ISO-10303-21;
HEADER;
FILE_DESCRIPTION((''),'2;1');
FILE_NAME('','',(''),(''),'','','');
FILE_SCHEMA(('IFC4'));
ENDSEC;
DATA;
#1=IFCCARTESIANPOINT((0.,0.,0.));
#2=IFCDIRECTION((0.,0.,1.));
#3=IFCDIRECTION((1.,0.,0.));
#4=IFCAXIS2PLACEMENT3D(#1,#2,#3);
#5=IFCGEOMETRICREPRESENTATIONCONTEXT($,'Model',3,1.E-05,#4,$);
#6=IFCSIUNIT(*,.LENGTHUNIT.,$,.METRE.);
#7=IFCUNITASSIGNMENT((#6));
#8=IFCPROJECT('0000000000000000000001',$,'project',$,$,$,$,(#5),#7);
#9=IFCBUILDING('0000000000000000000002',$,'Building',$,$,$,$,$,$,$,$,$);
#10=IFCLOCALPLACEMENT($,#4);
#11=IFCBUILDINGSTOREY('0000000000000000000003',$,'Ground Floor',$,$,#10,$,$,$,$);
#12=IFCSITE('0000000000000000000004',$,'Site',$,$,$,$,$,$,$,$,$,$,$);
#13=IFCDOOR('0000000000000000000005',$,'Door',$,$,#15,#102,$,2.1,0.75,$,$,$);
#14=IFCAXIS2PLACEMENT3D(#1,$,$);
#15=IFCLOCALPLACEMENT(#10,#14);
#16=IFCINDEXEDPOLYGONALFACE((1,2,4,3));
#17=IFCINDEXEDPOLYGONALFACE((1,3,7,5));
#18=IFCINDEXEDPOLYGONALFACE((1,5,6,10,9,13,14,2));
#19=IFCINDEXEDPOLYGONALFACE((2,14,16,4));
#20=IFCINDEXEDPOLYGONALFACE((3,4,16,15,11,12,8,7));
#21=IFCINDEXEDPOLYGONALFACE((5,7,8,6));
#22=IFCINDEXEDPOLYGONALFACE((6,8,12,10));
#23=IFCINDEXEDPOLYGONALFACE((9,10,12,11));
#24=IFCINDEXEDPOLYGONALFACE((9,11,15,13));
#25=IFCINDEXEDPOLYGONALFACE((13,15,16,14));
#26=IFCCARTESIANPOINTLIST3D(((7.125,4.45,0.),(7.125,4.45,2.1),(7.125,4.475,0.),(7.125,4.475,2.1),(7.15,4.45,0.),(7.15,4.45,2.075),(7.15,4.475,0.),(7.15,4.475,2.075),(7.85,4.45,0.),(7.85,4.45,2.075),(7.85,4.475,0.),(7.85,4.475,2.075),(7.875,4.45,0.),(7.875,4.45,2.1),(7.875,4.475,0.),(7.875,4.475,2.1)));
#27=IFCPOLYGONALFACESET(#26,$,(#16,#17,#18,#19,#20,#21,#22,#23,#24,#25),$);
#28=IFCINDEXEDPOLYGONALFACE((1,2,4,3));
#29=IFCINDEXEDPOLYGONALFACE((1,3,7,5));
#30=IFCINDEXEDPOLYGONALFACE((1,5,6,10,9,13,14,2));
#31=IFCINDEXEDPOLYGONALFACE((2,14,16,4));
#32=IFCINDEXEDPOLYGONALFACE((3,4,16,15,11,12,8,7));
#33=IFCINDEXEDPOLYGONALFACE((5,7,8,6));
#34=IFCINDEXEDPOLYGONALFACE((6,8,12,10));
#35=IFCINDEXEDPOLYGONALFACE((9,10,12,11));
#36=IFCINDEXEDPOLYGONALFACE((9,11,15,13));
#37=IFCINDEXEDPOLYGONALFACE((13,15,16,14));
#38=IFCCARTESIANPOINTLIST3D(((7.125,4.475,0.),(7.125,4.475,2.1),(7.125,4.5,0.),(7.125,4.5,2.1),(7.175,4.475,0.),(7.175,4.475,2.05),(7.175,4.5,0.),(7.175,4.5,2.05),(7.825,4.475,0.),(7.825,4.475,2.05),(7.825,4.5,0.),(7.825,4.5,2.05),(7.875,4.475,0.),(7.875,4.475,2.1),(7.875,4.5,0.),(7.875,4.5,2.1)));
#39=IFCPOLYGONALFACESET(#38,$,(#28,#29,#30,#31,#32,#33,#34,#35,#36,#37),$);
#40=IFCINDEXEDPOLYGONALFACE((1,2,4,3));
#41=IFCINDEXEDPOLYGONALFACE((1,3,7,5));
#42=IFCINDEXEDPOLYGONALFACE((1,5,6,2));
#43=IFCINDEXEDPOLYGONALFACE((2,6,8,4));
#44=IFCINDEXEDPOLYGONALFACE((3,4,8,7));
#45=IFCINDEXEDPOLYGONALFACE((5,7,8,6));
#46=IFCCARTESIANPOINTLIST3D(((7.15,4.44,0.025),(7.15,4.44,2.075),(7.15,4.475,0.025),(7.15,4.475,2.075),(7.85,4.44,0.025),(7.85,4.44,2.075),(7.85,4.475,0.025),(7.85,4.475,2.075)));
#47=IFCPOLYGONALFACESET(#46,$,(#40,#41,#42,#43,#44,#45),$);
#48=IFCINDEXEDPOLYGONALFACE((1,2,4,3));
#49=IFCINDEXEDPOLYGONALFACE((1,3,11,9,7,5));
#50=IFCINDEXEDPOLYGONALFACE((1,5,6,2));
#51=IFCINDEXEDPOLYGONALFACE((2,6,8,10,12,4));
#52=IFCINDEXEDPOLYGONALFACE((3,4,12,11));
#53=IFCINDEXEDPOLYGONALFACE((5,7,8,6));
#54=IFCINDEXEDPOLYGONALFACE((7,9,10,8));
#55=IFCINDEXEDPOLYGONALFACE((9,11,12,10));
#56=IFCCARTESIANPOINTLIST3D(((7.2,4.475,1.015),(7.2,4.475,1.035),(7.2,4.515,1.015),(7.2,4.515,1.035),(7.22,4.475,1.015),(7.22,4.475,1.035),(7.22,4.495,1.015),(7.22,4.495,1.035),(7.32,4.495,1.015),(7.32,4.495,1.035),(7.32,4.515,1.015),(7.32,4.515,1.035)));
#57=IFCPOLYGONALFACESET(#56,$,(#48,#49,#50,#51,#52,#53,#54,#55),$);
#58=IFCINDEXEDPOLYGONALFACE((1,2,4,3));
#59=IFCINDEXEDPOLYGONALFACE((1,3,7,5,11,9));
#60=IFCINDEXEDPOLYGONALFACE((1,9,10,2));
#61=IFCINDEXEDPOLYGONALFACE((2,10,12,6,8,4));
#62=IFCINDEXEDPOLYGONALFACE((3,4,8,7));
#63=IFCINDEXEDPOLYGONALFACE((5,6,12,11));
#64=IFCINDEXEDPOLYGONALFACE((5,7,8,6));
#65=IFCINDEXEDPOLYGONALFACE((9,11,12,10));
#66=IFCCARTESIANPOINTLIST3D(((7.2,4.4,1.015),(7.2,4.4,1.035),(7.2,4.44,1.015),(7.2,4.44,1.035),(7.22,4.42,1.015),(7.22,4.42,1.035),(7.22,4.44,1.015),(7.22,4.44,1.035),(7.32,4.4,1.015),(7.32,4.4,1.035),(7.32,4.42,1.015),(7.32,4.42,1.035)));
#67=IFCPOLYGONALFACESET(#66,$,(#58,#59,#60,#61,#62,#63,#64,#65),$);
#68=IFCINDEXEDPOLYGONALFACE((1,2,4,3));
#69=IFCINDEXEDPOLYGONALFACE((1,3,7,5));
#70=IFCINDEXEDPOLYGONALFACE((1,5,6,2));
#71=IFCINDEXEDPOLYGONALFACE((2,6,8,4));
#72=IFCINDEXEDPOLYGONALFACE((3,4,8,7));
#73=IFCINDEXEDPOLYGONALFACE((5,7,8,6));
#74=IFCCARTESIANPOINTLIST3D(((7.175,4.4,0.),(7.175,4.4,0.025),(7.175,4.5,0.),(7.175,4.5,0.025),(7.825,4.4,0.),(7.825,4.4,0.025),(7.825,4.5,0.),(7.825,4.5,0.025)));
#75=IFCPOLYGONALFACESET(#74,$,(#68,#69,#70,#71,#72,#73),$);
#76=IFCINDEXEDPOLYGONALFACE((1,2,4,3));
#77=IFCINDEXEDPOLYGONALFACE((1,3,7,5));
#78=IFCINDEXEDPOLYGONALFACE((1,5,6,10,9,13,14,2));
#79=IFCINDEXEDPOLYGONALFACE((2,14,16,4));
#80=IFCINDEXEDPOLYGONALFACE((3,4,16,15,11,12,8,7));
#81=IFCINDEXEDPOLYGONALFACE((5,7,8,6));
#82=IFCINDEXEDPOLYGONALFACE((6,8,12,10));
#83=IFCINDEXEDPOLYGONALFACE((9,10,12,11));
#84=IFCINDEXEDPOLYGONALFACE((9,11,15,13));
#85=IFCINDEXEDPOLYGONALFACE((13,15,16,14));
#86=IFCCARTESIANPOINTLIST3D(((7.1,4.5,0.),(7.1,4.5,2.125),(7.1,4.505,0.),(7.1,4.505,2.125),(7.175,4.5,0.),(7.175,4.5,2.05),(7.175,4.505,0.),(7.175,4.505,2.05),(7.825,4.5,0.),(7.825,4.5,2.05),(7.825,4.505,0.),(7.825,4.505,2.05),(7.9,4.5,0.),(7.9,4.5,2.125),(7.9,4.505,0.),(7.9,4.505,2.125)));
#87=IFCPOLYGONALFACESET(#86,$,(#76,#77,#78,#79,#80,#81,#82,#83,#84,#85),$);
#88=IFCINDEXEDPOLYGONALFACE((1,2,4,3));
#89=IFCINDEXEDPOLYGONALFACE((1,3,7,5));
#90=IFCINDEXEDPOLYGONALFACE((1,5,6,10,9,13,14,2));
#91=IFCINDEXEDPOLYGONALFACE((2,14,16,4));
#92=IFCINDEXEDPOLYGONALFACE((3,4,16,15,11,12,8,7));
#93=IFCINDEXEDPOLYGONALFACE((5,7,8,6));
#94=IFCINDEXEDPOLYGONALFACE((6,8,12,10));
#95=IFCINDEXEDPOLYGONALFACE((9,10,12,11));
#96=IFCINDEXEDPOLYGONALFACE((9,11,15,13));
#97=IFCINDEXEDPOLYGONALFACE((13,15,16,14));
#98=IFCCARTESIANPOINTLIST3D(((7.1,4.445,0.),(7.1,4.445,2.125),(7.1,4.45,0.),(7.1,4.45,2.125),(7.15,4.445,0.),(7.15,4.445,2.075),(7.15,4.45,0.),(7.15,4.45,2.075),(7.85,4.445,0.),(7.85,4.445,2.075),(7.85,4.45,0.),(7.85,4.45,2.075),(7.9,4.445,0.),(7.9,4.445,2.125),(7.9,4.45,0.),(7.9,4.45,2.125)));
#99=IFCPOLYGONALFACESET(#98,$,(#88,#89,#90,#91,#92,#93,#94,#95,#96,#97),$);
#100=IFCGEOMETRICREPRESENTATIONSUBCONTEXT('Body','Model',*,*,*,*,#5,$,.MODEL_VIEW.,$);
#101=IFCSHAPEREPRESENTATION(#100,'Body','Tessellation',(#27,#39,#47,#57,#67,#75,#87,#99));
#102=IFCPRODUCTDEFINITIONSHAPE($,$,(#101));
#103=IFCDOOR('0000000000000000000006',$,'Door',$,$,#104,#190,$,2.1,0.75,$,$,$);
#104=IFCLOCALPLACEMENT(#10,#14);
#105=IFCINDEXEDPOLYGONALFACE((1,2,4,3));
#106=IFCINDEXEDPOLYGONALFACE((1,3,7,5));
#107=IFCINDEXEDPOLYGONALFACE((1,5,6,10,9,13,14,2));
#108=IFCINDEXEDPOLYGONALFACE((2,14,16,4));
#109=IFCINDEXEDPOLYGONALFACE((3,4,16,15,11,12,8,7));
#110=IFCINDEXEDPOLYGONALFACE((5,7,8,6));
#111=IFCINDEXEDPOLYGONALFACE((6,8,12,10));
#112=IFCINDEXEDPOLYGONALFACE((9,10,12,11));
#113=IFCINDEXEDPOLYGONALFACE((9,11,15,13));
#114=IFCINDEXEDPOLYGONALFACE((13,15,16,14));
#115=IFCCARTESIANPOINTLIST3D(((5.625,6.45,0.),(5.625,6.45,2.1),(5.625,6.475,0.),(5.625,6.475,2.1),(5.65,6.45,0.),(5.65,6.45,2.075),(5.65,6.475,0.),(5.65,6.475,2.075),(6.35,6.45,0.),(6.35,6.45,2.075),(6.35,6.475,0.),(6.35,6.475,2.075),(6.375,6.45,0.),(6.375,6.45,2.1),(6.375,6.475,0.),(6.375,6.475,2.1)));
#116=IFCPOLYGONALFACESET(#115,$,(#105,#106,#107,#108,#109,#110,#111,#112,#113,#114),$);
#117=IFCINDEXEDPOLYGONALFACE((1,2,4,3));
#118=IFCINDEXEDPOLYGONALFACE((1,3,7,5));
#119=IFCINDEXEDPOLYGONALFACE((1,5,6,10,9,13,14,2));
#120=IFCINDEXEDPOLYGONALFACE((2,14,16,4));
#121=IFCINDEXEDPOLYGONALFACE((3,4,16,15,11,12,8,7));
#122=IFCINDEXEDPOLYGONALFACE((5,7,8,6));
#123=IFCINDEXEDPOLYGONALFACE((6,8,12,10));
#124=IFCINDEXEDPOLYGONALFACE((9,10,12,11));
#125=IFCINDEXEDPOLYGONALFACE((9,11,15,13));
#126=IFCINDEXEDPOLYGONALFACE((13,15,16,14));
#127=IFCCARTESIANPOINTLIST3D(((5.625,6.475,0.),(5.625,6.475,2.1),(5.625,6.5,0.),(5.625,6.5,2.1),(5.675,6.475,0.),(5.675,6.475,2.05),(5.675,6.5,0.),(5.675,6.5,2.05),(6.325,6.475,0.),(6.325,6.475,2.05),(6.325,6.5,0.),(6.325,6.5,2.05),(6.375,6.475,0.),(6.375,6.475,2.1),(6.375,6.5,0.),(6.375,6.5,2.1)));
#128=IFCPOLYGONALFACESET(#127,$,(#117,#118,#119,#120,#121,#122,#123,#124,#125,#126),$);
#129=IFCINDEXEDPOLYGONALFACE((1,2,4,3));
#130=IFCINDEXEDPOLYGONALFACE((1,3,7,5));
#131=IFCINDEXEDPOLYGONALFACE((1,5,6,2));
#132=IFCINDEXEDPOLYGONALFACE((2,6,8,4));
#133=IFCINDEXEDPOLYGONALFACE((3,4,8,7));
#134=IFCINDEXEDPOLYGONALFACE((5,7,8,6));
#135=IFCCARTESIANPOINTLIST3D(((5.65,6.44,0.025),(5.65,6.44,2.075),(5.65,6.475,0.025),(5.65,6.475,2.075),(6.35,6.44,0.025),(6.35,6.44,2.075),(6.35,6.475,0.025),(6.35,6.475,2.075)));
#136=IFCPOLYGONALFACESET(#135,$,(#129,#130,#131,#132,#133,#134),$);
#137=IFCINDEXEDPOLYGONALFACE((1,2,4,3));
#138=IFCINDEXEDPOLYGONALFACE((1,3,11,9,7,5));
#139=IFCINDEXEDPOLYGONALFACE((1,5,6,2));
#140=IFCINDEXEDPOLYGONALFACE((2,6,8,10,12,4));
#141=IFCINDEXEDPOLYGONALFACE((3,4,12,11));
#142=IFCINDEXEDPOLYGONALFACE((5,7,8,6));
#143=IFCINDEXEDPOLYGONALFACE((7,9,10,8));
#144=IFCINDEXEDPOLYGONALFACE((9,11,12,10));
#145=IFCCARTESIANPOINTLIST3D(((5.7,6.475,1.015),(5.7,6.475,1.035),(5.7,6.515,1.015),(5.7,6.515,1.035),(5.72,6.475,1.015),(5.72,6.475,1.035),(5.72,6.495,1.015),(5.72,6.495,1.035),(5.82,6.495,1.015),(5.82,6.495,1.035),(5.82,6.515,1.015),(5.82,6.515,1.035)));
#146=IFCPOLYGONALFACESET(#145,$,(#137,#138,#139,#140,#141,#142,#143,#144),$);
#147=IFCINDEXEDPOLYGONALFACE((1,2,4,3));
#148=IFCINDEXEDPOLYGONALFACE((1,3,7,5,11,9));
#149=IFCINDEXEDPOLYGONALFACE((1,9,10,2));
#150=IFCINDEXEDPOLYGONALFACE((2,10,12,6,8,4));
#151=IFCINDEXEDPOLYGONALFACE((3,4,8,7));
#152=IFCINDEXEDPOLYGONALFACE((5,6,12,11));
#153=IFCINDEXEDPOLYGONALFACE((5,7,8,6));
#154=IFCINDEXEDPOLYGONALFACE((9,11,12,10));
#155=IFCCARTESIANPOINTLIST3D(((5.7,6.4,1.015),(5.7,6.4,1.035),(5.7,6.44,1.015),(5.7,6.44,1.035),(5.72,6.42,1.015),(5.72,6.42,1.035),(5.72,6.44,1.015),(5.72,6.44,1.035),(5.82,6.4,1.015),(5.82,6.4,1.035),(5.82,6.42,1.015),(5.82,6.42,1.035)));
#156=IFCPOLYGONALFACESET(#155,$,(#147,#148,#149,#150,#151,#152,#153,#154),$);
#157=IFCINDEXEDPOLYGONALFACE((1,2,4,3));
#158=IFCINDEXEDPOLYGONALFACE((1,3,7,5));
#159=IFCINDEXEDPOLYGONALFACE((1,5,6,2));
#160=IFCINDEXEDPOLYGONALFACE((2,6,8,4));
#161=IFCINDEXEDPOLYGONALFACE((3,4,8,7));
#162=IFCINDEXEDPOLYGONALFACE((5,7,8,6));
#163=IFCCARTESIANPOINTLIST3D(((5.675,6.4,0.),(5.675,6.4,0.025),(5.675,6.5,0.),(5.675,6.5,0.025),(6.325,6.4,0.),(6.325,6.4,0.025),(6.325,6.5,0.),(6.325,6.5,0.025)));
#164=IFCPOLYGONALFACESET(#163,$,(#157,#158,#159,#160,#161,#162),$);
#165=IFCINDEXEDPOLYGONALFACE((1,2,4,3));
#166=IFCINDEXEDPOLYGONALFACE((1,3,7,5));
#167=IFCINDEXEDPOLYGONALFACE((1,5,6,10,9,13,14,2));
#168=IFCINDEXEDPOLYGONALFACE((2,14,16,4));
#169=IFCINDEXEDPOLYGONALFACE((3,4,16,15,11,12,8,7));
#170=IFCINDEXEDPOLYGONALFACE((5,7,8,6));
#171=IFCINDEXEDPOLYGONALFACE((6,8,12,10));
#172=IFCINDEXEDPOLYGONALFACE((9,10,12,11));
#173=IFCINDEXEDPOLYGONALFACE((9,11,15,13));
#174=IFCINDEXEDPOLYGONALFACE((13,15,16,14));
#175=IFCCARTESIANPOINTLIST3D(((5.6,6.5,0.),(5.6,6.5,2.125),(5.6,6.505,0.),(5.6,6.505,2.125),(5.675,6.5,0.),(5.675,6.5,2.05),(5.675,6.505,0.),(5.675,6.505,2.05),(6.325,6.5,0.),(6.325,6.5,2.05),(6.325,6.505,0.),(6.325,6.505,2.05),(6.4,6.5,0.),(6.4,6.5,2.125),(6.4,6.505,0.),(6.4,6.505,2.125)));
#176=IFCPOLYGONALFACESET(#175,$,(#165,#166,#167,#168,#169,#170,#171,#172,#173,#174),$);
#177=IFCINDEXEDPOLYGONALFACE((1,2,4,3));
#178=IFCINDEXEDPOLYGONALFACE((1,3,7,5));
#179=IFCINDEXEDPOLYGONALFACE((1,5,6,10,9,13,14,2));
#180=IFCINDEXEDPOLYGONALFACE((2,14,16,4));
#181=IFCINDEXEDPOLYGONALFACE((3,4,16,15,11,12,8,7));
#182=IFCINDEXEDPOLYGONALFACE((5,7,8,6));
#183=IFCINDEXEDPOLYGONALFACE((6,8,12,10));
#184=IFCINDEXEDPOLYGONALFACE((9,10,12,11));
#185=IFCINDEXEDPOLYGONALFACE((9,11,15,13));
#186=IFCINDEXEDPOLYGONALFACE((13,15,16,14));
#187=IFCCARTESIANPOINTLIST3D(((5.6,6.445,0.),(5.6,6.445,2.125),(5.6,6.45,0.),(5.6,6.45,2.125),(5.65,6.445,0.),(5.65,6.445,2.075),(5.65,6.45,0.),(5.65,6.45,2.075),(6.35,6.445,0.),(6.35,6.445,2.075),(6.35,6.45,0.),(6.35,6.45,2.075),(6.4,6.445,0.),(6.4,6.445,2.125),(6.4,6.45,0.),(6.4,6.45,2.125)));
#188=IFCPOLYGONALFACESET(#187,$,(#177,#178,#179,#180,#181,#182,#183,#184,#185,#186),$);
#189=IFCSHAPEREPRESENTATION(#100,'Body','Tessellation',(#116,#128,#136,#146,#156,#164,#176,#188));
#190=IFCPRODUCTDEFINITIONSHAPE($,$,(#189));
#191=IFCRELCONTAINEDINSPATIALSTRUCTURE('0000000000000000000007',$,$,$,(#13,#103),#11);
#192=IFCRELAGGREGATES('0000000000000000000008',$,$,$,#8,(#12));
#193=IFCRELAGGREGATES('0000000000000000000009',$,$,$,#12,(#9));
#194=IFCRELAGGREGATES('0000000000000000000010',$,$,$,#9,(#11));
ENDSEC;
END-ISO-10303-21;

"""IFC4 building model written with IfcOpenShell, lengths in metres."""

from ifc_helpers import new_model, si_unit, frame, origin_with_axes, place, context, subcontext, project, spatial, line, indexed_curve, outline, extrude, element, save


model = new_model("IFC4")

# Units and contexts
model_context = context("Model", 3, precision=1e-05, world=origin_with_axes())
body_context = subcontext(model_context, "Body", "Model", "MODEL_VIEW")
ifc_project = project(units=[si_unit("LENGTHUNIT", "METRE")], contexts=[model_context])

# Site, building, storey
site = spatial("IfcSite", under=ifc_project, Name="Site")
building = spatial("IfcBuilding", under=site, Name="Building")
storey_placement = place(None, origin_with_axes())
storey = spatial("IfcBuildingStorey", under=building, at=storey_placement, Name="Ground Floor")

# Doors
door_1_placement = place(storey_placement, frame((7.875, 4.5, 0.0), z_axis=(0.0, 0.0, 1.0), x_axis=(-1.0, 0.0, 0.0)))
element("IfcDoor", 1, at=door_1_placement, inside=storey, Name="Door", OverallHeight=2.1, OverallWidth=0.75, context=body_context, shape_type="SweptSolid", body=[
    extrude(outline(indexed_curve([(0.0, 0.0), (0.0, 2.1), (0.75, 2.1), (0.75, 0.0), (0.725, 0.0), (0.725, 2.075), (0.025, 2.075), (0.025, 0.0)], segments=[line(1, 2, 3, 4, 5, 6, 7, 8, 1)])), frame((0.0, 0.025, 0.0), z_axis=(0.0, -1.0, 0.0), x_axis=(1.0, 0.0, 0.0)), (0.0, 0.0, -1.0), 0.025),
    extrude(outline(indexed_curve([(0.0, 0.0), (0.0, 2.1), (0.75, 2.1), (0.75, 0.0), (0.7, 0.0), (0.7, 2.05), (0.05, 2.05), (0.05, 0.0)], segments=[line(1, 2, 3, 4, 5, 6, 7, 8, 1)])), frame((0.0, 0.0, 0.0), z_axis=(0.0, -1.0, 0.0), x_axis=(1.0, 0.0, 0.0)), (0.0, 0.0, -1.0), 0.025),
    extrude(outline(indexed_curve([(0.0, 0.0), (0.7, 0.0), (0.7, 0.035), (0.0, 0.035)], segments=[line(1, 2, 3, 4, 1)])), frame((0.025, 0.025, 0.025), z_axis=(0.0, 0.0, 1.0), x_axis=(1.0, 0.0, 0.0)), (0.0, 0.0, 1.0), 2.05),
    extrude(outline(indexed_curve([(0.0, 0.0), (0.0, -0.04), (-0.12, -0.04), (-0.12, -0.02), (-0.02, -0.02), (-0.02, 0.0)], segments=[line(1, 2, 3, 4, 5, 6, 1)])), frame((0.675, 0.025, 1.015), z_axis=(0.0, 0.0, 1.0), x_axis=(1.0, 0.0, 0.0)), (0.0, 0.0, 1.0), 0.02),
    extrude(outline(indexed_curve([(0.0, 0.0), (0.0, 0.04), (-0.12, 0.04), (-0.12, 0.02), (-0.02, 0.02), (-0.02, 0.0)], segments=[line(1, 2, 3, 4, 5, 6, 1)])), frame((0.675, 0.06, 1.015), z_axis=(0.0, 0.0, 1.0), x_axis=(1.0, 0.0, 0.0)), (0.0, 0.0, 1.0), 0.02),
    extrude(outline(indexed_curve([(0.0, 0.0), (0.65, 0.0), (0.65, 0.1), (0.0, 0.1)], segments=[line(1, 2, 3, 4, 1)])), frame((0.05, 0.0, 0.0), z_axis=(0.0, 0.0, 1.0), x_axis=(1.0, 0.0, 0.0)), (0.0, 0.0, 1.0), 0.025),
    extrude(outline(indexed_curve([(0.0, 0.0), (0.0, 2.125), (0.8, 2.125), (0.8, 0.0), (0.725, 0.0), (0.725, 2.05), (0.075, 2.05), (0.075, 0.0)], segments=[line(1, 2, 3, 4, 5, 6, 7, 8, 1)])), frame((-0.025, -0.005, 0.0), z_axis=(0.0, -1.0, 0.0), x_axis=(1.0, 0.0, 0.0)), (0.0, 0.0, -1.0), 0.005),
    extrude(outline(indexed_curve([(0.0, 0.0), (0.0, 2.125), (0.8, 2.125), (0.8, 0.0), (0.75, 0.0), (0.75, 2.075), (0.05, 2.075), (0.05, 0.0)], segments=[line(1, 2, 3, 4, 5, 6, 7, 8, 1)])), frame((-0.025, 0.05, 0.0), z_axis=(0.0, -1.0, 0.0), x_axis=(1.0, 0.0, 0.0)), (0.0, 0.0, -1.0), 0.005),
])
door_2_placement = place(storey_placement, frame((6.375, 6.5, 0.0), z_axis=(0.0, 0.0, 1.0), x_axis=(-1.0, 0.0, 0.0)))
element("IfcDoor", 2, at=door_2_placement, inside=storey, Name="Door", OverallHeight=2.1, OverallWidth=0.75, context=body_context, shape_type="SweptSolid", body=[
    extrude(outline(indexed_curve([(0.0, 0.0), (0.0, 2.1), (0.75, 2.1), (0.75, 0.0), (0.725, 0.0), (0.725, 2.075), (0.025, 2.075), (0.025, 0.0)], segments=[line(1, 2, 3, 4, 5, 6, 7, 8, 1)])), frame((0.0, 0.025, 0.0), z_axis=(0.0, -1.0, 0.0), x_axis=(1.0, 0.0, 0.0)), (0.0, 0.0, -1.0), 0.025),
    extrude(outline(indexed_curve([(0.0, 0.0), (0.0, 2.1), (0.75, 2.1), (0.75, 0.0), (0.7, 0.0), (0.7, 2.05), (0.05, 2.05), (0.05, 0.0)], segments=[line(1, 2, 3, 4, 5, 6, 7, 8, 1)])), frame((0.0, 0.0, 0.0), z_axis=(0.0, -1.0, 0.0), x_axis=(1.0, 0.0, 0.0)), (0.0, 0.0, -1.0), 0.025),
    extrude(outline(indexed_curve([(0.0, 0.0), (0.7, 0.0), (0.7, 0.035), (0.0, 0.035)], segments=[line(1, 2, 3, 4, 1)])), frame((0.025, 0.025, 0.025), z_axis=(0.0, 0.0, 1.0), x_axis=(1.0, 0.0, 0.0)), (0.0, 0.0, 1.0), 2.05),
    extrude(outline(indexed_curve([(0.0, 0.0), (0.0, -0.04), (-0.12, -0.04), (-0.12, -0.02), (-0.02, -0.02), (-0.02, 0.0)], segments=[line(1, 2, 3, 4, 5, 6, 1)])), frame((0.675, 0.025, 1.015), z_axis=(0.0, 0.0, 1.0), x_axis=(1.0, 0.0, 0.0)), (0.0, 0.0, 1.0), 0.02),
    extrude(outline(indexed_curve([(0.0, 0.0), (0.0, 0.04), (-0.12, 0.04), (-0.12, 0.02), (-0.02, 0.02), (-0.02, 0.0)], segments=[line(1, 2, 3, 4, 5, 6, 1)])), frame((0.675, 0.06, 1.015), z_axis=(0.0, 0.0, 1.0), x_axis=(1.0, 0.0, 0.0)), (0.0, 0.0, 1.0), 0.02),
    extrude(outline(indexed_curve([(0.0, 0.0), (0.65, 0.0), (0.65, 0.1), (0.0, 0.1)], segments=[line(1, 2, 3, 4, 1)])), frame((0.05, 0.0, 0.0), z_axis=(0.0, 0.0, 1.0), x_axis=(1.0, 0.0, 0.0)), (0.0, 0.0, 1.0), 0.025),
    extrude(outline(indexed_curve([(0.0, 0.0), (0.0, 2.125), (0.8, 2.125), (0.8, 0.0), (0.725, 0.0), (0.725, 2.05), (0.075, 2.05), (0.075, 0.0)], segments=[line(1, 2, 3, 4, 5, 6, 7, 8, 1)])), frame((-0.025, -0.005, 0.0), z_axis=(0.0, -1.0, 0.0), x_axis=(1.0, 0.0, 0.0)), (0.0, 0.0, -1.0), 0.005),
    extrude(outline(indexed_curve([(0.0, 0.0), (0.0, 2.125), (0.8, 2.125), (0.8, 0.0), (0.75, 0.0), (0.75, 2.075), (0.05, 2.075), (0.05, 0.0)], segments=[line(1, 2, 3, 4, 5, 6, 7, 8, 1)])), frame((-0.025, 0.05, 0.0), z_axis=(0.0, -1.0, 0.0), x_axis=(1.0, 0.0, 0.0)), (0.0, 0.0, -1.0), 0.005),
])

save(model, "model.ifc")
